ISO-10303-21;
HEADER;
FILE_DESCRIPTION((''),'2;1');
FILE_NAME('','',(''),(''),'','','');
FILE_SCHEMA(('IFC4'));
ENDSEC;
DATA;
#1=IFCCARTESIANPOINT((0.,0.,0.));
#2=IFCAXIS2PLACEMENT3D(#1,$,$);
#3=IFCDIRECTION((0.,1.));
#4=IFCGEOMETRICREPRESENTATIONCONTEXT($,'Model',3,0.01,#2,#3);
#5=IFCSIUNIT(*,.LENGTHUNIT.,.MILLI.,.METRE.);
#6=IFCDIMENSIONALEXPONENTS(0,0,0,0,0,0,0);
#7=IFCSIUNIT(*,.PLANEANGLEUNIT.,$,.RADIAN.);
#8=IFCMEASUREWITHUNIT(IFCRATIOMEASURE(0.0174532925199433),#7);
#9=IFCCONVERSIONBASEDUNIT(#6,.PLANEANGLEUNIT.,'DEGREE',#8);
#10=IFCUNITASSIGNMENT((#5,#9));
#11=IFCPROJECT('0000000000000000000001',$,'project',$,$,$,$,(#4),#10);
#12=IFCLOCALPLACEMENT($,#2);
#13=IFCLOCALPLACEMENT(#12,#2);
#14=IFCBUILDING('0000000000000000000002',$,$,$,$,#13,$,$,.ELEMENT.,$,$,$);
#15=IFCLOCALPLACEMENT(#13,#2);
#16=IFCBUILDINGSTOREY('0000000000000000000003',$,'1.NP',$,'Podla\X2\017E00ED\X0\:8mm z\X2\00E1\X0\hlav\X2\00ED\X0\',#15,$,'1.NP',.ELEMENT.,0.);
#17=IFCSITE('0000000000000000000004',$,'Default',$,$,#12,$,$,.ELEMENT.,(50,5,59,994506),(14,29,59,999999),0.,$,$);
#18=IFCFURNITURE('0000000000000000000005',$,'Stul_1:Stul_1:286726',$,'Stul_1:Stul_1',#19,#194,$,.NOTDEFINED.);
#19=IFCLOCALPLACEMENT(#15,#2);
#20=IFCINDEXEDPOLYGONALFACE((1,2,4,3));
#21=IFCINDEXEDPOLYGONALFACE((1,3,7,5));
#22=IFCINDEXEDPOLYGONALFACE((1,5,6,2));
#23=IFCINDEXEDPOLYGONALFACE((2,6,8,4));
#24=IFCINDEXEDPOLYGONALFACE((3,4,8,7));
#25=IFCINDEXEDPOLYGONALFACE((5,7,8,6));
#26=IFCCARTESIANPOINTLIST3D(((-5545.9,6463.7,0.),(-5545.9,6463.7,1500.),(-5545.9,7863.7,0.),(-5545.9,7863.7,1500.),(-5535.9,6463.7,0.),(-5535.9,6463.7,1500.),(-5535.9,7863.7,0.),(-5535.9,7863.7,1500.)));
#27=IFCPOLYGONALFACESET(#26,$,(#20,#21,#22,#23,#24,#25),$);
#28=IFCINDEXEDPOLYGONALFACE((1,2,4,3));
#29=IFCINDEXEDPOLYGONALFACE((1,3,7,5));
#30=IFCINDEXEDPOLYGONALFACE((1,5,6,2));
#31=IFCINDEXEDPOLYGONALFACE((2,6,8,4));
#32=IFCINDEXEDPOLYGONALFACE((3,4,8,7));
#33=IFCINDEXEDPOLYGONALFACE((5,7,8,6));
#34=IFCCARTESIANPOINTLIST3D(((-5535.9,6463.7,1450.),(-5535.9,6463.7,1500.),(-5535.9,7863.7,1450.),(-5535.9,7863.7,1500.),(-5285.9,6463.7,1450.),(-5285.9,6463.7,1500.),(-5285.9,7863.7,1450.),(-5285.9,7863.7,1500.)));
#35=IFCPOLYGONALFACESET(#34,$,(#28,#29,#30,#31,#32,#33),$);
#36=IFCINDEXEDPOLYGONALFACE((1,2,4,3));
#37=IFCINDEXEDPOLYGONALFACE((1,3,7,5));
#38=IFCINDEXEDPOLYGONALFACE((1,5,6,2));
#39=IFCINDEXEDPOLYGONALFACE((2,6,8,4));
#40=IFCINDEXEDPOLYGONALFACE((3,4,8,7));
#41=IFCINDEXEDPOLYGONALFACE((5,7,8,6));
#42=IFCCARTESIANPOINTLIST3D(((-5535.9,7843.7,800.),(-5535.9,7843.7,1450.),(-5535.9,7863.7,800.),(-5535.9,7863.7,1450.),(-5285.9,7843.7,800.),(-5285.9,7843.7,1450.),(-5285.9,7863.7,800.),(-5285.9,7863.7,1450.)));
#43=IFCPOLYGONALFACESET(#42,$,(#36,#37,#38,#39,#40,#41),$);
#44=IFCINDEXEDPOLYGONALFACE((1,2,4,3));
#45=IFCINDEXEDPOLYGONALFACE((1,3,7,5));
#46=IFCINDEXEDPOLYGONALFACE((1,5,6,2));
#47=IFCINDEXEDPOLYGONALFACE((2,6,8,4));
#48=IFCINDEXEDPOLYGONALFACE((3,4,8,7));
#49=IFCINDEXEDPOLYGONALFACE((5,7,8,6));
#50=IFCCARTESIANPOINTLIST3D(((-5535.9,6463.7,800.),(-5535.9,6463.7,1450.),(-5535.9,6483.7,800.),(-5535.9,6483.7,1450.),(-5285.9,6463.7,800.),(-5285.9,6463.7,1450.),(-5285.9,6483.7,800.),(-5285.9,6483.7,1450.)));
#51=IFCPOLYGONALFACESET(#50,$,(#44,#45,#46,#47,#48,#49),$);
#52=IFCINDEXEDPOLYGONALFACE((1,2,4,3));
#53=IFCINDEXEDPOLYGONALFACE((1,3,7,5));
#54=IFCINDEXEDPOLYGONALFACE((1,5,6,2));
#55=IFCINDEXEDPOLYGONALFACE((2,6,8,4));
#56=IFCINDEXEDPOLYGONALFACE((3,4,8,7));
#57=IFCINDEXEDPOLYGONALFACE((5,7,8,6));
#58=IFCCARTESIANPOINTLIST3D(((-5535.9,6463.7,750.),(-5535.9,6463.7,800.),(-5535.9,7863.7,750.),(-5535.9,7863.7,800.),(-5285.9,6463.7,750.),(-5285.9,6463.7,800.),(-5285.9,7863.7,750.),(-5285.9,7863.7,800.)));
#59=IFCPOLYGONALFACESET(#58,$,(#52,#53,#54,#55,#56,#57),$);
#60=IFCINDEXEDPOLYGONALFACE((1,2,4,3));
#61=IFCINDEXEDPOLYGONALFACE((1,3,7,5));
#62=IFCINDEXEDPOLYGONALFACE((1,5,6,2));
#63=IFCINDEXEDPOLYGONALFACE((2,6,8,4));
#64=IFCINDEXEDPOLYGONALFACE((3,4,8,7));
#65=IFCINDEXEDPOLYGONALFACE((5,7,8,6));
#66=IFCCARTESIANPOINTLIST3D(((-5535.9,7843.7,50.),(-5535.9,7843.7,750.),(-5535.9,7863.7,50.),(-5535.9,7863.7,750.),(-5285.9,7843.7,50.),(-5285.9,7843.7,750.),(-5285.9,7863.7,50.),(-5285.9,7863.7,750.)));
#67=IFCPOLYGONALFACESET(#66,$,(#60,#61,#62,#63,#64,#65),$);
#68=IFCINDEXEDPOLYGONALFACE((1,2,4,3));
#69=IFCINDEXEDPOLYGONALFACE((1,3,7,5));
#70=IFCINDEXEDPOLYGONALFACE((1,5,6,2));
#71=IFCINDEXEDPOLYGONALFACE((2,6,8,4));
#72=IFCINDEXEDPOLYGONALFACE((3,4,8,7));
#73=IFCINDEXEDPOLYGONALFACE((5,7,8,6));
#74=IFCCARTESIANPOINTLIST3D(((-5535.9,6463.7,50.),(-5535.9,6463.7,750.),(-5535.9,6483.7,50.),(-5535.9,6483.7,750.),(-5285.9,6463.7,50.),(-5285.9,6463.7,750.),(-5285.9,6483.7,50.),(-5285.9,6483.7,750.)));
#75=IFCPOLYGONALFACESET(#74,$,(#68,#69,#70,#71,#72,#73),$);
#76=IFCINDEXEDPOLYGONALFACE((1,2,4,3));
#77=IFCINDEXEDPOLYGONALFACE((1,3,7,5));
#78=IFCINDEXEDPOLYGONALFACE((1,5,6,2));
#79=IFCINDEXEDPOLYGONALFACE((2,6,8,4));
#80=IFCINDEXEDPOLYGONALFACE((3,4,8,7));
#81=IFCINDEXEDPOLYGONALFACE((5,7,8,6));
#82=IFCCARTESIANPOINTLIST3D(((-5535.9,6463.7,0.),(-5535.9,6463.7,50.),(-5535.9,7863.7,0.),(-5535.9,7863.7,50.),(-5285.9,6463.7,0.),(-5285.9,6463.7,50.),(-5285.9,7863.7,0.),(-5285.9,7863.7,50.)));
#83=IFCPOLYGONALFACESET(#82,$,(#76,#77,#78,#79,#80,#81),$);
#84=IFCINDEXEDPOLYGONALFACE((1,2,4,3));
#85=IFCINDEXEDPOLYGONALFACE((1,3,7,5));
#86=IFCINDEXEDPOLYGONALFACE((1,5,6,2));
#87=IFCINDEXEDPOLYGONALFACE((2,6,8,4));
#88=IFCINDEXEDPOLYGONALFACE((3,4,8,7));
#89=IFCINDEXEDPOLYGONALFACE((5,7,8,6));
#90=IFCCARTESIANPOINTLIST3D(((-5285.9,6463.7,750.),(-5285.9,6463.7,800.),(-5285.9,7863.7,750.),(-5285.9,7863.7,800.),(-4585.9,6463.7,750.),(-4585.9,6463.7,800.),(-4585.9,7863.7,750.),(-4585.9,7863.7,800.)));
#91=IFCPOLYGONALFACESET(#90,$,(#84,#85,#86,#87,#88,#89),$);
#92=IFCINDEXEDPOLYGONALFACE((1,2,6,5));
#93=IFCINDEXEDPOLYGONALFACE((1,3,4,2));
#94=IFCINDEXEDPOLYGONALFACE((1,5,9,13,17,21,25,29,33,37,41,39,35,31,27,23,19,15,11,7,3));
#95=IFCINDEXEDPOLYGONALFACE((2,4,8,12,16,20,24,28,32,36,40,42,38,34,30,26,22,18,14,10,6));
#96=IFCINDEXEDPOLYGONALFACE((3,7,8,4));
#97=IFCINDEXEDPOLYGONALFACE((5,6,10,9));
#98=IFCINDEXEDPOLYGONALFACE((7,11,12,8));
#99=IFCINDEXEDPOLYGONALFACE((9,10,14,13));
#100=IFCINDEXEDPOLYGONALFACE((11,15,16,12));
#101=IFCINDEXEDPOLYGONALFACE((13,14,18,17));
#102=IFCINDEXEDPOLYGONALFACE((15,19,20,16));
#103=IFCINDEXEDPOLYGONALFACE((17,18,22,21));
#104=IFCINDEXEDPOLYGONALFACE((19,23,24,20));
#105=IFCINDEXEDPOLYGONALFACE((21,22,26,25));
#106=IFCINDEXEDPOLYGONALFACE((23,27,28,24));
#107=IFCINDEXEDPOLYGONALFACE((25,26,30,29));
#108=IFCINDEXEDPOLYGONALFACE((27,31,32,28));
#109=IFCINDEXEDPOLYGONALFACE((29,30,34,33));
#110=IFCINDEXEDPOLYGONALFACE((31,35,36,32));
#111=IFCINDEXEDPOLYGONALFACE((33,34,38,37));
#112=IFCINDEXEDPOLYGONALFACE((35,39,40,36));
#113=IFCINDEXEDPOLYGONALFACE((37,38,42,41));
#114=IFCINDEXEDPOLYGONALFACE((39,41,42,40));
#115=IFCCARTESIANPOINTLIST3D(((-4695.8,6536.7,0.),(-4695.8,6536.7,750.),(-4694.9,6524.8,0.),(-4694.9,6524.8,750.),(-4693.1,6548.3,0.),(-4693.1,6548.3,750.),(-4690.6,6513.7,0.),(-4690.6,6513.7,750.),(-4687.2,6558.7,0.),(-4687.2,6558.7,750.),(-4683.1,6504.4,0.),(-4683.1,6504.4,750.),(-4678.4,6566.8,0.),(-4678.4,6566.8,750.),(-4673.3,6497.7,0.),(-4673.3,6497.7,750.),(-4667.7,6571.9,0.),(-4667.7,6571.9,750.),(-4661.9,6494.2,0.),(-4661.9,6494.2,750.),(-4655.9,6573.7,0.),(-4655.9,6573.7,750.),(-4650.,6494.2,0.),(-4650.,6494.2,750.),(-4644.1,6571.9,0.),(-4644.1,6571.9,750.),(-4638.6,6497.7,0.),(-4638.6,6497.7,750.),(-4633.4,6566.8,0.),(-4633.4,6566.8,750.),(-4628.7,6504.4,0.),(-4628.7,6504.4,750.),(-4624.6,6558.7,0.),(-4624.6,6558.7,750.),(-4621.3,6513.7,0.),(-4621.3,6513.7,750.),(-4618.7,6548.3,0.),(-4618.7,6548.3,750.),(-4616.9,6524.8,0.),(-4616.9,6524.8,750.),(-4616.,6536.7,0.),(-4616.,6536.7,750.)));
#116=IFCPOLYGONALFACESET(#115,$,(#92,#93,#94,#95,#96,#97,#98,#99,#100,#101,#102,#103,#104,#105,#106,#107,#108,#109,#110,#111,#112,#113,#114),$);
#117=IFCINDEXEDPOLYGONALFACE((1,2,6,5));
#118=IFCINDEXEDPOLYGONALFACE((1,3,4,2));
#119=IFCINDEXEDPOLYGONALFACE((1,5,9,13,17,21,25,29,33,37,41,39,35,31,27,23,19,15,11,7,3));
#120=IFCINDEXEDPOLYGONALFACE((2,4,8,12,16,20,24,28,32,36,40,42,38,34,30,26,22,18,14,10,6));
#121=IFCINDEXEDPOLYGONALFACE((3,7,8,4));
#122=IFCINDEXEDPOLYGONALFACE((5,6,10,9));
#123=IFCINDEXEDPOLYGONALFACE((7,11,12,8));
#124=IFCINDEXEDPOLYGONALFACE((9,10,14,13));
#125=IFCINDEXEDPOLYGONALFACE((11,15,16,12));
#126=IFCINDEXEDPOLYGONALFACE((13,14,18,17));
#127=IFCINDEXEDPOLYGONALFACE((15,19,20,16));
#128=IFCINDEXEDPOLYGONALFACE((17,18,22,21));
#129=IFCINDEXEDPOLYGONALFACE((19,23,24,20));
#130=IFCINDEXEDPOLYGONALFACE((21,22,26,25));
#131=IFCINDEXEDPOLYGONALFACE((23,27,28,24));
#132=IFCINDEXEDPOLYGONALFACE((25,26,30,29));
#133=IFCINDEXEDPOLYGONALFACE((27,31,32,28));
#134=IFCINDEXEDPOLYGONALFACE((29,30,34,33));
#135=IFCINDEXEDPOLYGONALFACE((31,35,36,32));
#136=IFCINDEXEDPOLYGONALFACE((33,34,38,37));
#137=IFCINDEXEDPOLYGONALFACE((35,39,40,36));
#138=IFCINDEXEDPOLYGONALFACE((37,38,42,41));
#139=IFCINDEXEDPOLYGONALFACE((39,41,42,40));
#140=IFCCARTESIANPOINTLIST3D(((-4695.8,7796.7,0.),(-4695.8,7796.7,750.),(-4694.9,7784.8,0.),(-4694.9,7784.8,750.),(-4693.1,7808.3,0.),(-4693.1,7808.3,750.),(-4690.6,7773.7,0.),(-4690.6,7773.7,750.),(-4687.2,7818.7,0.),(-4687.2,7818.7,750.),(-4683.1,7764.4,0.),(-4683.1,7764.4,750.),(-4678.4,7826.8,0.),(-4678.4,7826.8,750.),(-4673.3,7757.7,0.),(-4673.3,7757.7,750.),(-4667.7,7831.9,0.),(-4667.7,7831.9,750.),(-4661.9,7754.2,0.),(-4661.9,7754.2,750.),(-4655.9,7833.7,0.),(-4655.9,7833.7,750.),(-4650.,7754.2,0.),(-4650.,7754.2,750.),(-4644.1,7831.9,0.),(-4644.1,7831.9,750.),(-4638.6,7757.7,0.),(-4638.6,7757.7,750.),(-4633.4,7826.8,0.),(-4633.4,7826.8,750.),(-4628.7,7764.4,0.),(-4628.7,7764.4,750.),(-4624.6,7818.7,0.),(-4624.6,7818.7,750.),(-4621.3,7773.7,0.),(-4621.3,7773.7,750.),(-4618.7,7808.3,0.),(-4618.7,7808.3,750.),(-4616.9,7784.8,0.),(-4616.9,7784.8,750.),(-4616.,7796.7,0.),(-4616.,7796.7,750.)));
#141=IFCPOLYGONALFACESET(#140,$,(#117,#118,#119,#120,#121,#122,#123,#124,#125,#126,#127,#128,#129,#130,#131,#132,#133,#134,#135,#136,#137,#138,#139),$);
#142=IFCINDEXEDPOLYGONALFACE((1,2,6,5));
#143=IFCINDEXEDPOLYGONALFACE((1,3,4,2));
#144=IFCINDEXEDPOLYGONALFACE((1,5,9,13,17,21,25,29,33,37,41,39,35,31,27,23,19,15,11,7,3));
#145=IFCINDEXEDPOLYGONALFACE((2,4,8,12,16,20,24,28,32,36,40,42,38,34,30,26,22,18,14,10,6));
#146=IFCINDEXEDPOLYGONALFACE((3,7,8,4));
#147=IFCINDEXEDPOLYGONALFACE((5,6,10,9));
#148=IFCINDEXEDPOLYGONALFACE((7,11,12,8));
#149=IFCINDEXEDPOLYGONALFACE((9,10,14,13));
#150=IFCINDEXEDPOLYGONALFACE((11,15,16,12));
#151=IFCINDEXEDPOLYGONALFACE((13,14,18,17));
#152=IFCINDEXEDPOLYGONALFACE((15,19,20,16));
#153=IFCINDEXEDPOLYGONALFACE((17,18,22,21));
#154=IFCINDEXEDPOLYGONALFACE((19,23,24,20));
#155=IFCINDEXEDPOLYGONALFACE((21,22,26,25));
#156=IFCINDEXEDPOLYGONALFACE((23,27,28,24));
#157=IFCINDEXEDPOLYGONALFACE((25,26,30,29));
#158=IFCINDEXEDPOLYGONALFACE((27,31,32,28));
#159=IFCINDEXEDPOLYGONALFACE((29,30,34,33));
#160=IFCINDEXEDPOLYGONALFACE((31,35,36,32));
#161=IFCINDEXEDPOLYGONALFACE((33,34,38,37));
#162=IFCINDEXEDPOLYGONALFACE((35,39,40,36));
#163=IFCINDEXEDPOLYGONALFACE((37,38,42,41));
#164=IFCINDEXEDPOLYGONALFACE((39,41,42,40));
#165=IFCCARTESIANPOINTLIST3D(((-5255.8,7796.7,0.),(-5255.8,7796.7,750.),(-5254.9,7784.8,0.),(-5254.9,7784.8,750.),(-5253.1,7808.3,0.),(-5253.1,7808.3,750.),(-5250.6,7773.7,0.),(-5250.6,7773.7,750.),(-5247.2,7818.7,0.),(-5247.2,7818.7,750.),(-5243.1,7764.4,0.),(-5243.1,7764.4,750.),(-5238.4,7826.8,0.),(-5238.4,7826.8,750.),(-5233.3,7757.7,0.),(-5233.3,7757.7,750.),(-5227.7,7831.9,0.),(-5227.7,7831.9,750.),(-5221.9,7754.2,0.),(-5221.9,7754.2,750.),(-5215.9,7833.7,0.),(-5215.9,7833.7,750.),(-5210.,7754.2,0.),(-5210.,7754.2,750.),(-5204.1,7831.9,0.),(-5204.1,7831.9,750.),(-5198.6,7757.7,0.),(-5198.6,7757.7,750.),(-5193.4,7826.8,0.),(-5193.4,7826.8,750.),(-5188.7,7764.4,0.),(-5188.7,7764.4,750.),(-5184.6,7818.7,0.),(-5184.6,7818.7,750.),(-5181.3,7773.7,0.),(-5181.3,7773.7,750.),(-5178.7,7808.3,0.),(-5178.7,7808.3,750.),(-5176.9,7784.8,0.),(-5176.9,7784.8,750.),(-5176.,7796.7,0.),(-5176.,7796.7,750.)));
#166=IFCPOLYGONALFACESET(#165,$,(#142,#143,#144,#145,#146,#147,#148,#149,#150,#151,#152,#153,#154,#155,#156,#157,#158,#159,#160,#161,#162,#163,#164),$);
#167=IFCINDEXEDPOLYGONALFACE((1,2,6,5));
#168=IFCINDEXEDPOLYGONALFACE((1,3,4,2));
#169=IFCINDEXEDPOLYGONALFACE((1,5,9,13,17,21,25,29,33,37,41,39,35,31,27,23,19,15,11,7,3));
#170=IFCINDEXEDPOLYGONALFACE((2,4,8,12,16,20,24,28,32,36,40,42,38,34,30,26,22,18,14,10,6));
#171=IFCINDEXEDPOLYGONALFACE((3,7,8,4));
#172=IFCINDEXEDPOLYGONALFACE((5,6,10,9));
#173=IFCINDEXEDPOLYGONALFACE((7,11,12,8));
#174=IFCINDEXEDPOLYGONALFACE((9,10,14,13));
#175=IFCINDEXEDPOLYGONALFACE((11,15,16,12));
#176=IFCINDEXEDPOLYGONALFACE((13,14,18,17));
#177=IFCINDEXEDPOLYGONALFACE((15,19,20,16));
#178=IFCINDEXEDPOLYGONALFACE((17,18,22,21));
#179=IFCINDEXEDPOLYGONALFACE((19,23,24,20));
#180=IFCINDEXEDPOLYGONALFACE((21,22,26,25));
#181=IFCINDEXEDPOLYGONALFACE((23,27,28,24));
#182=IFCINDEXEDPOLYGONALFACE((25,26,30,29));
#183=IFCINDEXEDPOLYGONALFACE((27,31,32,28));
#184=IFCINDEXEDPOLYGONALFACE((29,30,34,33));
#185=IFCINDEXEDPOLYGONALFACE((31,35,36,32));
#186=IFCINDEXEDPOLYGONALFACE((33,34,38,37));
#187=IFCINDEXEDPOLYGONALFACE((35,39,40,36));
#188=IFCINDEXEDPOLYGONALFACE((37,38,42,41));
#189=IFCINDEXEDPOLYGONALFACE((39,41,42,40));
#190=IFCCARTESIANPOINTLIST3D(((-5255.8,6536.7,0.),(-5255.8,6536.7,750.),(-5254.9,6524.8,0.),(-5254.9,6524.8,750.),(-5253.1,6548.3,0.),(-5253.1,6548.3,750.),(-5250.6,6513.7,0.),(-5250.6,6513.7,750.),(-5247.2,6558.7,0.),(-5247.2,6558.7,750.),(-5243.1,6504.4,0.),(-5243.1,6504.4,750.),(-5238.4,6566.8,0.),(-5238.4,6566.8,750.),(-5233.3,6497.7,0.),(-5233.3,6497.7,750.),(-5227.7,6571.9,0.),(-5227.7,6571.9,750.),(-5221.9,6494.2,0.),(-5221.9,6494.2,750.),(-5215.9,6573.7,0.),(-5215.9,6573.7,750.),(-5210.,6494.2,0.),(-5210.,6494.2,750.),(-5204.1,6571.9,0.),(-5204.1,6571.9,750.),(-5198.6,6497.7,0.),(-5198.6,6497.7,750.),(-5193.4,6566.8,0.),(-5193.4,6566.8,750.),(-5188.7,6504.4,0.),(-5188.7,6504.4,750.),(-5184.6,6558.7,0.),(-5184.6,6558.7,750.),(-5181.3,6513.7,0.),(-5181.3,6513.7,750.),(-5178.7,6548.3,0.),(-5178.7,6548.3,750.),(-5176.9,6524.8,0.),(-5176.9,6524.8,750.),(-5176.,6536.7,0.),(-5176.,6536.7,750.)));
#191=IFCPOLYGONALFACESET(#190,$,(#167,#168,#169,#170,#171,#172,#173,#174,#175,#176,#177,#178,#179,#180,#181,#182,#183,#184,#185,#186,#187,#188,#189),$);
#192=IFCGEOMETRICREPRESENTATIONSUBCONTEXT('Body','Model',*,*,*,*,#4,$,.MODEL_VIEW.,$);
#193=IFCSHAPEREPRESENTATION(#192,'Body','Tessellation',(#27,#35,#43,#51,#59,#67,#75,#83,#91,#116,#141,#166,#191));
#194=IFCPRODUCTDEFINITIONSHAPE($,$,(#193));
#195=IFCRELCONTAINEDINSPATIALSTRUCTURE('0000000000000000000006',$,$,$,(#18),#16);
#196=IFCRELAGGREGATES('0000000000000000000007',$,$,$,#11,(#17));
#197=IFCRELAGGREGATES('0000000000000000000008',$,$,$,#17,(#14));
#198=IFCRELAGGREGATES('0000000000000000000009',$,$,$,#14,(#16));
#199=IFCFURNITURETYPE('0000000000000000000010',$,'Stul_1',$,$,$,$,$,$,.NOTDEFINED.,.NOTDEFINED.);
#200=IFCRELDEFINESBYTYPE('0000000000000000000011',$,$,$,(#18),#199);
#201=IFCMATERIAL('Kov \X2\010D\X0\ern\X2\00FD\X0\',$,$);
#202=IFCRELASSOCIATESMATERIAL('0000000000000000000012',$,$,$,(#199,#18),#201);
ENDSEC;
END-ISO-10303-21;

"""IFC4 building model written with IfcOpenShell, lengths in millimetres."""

from ifc_helpers import new_model, entity, si_unit, converted_unit, direction, frame, frame_2d, origin, origin_2d_with_axis, place, context, subcontext, project, spatial, rectangle, circle, extrude, source, transform, mapped, material, type_object, type_shapes, element, save


model = new_model("IFC4")

# Units and contexts
model_context = context("Model", 3, precision=0.01, world=origin(), true_north=direction((0.0, 1.0)))
body_context = subcontext(model_context, "Body", "Model", "MODEL_VIEW")
ifc_project = project(units=[si_unit("LENGTHUNIT", "METRE", prefix="MILLI"), converted_unit("PLANEANGLEUNIT", "DEGREE", entity("IfcRatioMeasure", 0.0174532925199433), si_unit("PLANEANGLEUNIT", "RADIAN"), dimensions=[0, 0, 0, 0, 0, 0, 0])], contexts=[model_context])

# Site, building, storey
site_placement = place(None, origin())
site = spatial("IfcSite", under=ifc_project, at=site_placement, Name="Default", CompositionType="ELEMENT", RefLatitude=(50, 5, 59, 994506), RefLongitude=(14, 29, 59, 999999), RefElevation=0.0)
building_placement = place(site_placement, origin())
building = spatial("IfcBuilding", under=site, at=building_placement, CompositionType="ELEMENT")
storey_placement = place(building_placement, origin())
storey = spatial("IfcBuildingStorey", under=building, at=storey_placement, Name="1.NP", ObjectType="Podlaží:8mm záhlaví", LongName="1.NP", CompositionType="ELEMENT", Elevation=0.0)

# Furniture
ifc_material_1 = material(Name="Kov černý")
furniture_type = type_object("IfcFurnitureType", Name="Stul_1", AssemblyPlace="NOTDEFINED", PredefinedType="NOTDEFINED", material=ifc_material_1)
shared_shape_1 = source(origin(), body_context, "Body", "SweptSolid", [
    extrude(rectangle(XDim=1400.0, YDim=10.0, at=origin_2d_with_axis()), frame((0.0, 605.0, 0.0), z_axis=(0.0, 0.0, 1.0), x_axis=(-1.0, 0.0, 0.0)), (0.0, 0.0, 1.0), 1500.0),
    extrude(rectangle(XDim=1400.0, YDim=250.0, at=frame_2d((0.0, 0.0), x_axis=(1.0, 0.0))), frame((0.0, 475.0, 1450.0), z_axis=(0.0, 0.0, 1.0), x_axis=(-1.0, 0.0, 0.0)), (0.0, 0.0, 1.0), 50.0),
    extrude(rectangle(XDim=20.0, YDim=250.0, at=origin_2d_with_axis()), frame((690.0, 475.0, 800.0), z_axis=(0.0, 0.0, 1.0), x_axis=(-1.0, 0.0, 0.0)), (0.0, 0.0, 1.0), 650.0),
    extrude(rectangle(XDim=20.0, YDim=250.0, at=frame_2d((0.0, 0.0), x_axis=(1.0, 0.0))), frame((-690.0, 475.0, 800.0), z_axis=(0.0, 0.0, 1.0), x_axis=(-1.0, 0.0, 0.0)), (0.0, 0.0, 1.0), 650.0),
    extrude(rectangle(XDim=1400.0, YDim=250.0, at=origin_2d_with_axis()), frame((0.0, 475.0, 750.0), z_axis=(0.0, 0.0, 1.0), x_axis=(-1.0, 0.0, 0.0)), (0.0, 0.0, 1.0), 50.0),
    extrude(rectangle(XDim=20.0, YDim=250.0, at=origin_2d_with_axis()), frame((690.0, 475.0, 50.0), z_axis=(0.0, 0.0, 1.0), x_axis=(-1.0, 0.0, 0.0)), (0.0, 0.0, 1.0), 700.0),
    extrude(rectangle(XDim=20.0, YDim=250.0, at=frame_2d((0.0, 0.0), x_axis=(1.0, 0.0))), frame((-690.0, 475.0, 50.0), z_axis=(0.0, 0.0, 1.0), x_axis=(-1.0, 0.0, 0.0)), (0.0, 0.0, 1.0), 700.0),
    extrude(rectangle(XDim=1400.0, YDim=250.0, at=origin_2d_with_axis()), frame((0.0, 475.0, 0.0), z_axis=(0.0, 0.0, 1.0), x_axis=(-1.0, 0.0, 0.0)), (0.0, 0.0, 1.0), 50.0),
    extrude(rectangle(XDim=1400.0, YDim=700.0, at=origin_2d_with_axis()), frame((0.0, 0.0, 750.0), z_axis=(0.0, 0.0, 1.0), x_axis=(-1.0, 0.0, 0.0)), (0.0, 0.0, 1.0), 50.0),
    extrude(circle(Radius=40.0, at=frame_2d((0.0, 0.0), x_axis=(1.0, 0.0))), frame((-630.0, -280.0, 0.0)), (0.0, 0.0, 1.0), 750.0),
    extrude(circle(Radius=40.0, at=frame_2d((0.0, 0.0), x_axis=(1.0, 0.0))), frame((630.0, -280.0, 0.0)), (0.0, 0.0, 1.0), 750.0),
    extrude(circle(Radius=40.0, at=frame_2d((0.0, 0.0), x_axis=(1.0, 0.0))), frame((630.0, 280.0, 0.0)), (0.0, 0.0, 1.0), 750.0),
    extrude(circle(Radius=40.0, at=frame_2d((0.0, 0.0), x_axis=(1.0, 0.0))), frame((-630.0, 280.0, 0.0)), (0.0, 0.0, 1.0), 750.0),
])
type_shapes(furniture_type, [shared_shape_1])
for number, where, z_axis, x_axis, name in (
    (1, (-4935.9, 7163.7, 0.0), (0.0, 0.0, 1.0), (0.0, 1.0, 0.0), "Stul_1:Stul_1:286726"),
):
    element("IfcFurniture", number, at=place(storey_placement, frame(where, z_axis=z_axis, x_axis=x_axis)), inside=storey, type_object=furniture_type, material=ifc_material_1, Name=name, ObjectType="Stul_1:Stul_1", PredefinedType="NOTDEFINED", context=body_context, shape_type="MappedRepresentation", body=[
        mapped(shared_shape_1, transform((0.0, 0.0, 0.0), scale=1.0)),
    ])

save(model, "model.ifc")
